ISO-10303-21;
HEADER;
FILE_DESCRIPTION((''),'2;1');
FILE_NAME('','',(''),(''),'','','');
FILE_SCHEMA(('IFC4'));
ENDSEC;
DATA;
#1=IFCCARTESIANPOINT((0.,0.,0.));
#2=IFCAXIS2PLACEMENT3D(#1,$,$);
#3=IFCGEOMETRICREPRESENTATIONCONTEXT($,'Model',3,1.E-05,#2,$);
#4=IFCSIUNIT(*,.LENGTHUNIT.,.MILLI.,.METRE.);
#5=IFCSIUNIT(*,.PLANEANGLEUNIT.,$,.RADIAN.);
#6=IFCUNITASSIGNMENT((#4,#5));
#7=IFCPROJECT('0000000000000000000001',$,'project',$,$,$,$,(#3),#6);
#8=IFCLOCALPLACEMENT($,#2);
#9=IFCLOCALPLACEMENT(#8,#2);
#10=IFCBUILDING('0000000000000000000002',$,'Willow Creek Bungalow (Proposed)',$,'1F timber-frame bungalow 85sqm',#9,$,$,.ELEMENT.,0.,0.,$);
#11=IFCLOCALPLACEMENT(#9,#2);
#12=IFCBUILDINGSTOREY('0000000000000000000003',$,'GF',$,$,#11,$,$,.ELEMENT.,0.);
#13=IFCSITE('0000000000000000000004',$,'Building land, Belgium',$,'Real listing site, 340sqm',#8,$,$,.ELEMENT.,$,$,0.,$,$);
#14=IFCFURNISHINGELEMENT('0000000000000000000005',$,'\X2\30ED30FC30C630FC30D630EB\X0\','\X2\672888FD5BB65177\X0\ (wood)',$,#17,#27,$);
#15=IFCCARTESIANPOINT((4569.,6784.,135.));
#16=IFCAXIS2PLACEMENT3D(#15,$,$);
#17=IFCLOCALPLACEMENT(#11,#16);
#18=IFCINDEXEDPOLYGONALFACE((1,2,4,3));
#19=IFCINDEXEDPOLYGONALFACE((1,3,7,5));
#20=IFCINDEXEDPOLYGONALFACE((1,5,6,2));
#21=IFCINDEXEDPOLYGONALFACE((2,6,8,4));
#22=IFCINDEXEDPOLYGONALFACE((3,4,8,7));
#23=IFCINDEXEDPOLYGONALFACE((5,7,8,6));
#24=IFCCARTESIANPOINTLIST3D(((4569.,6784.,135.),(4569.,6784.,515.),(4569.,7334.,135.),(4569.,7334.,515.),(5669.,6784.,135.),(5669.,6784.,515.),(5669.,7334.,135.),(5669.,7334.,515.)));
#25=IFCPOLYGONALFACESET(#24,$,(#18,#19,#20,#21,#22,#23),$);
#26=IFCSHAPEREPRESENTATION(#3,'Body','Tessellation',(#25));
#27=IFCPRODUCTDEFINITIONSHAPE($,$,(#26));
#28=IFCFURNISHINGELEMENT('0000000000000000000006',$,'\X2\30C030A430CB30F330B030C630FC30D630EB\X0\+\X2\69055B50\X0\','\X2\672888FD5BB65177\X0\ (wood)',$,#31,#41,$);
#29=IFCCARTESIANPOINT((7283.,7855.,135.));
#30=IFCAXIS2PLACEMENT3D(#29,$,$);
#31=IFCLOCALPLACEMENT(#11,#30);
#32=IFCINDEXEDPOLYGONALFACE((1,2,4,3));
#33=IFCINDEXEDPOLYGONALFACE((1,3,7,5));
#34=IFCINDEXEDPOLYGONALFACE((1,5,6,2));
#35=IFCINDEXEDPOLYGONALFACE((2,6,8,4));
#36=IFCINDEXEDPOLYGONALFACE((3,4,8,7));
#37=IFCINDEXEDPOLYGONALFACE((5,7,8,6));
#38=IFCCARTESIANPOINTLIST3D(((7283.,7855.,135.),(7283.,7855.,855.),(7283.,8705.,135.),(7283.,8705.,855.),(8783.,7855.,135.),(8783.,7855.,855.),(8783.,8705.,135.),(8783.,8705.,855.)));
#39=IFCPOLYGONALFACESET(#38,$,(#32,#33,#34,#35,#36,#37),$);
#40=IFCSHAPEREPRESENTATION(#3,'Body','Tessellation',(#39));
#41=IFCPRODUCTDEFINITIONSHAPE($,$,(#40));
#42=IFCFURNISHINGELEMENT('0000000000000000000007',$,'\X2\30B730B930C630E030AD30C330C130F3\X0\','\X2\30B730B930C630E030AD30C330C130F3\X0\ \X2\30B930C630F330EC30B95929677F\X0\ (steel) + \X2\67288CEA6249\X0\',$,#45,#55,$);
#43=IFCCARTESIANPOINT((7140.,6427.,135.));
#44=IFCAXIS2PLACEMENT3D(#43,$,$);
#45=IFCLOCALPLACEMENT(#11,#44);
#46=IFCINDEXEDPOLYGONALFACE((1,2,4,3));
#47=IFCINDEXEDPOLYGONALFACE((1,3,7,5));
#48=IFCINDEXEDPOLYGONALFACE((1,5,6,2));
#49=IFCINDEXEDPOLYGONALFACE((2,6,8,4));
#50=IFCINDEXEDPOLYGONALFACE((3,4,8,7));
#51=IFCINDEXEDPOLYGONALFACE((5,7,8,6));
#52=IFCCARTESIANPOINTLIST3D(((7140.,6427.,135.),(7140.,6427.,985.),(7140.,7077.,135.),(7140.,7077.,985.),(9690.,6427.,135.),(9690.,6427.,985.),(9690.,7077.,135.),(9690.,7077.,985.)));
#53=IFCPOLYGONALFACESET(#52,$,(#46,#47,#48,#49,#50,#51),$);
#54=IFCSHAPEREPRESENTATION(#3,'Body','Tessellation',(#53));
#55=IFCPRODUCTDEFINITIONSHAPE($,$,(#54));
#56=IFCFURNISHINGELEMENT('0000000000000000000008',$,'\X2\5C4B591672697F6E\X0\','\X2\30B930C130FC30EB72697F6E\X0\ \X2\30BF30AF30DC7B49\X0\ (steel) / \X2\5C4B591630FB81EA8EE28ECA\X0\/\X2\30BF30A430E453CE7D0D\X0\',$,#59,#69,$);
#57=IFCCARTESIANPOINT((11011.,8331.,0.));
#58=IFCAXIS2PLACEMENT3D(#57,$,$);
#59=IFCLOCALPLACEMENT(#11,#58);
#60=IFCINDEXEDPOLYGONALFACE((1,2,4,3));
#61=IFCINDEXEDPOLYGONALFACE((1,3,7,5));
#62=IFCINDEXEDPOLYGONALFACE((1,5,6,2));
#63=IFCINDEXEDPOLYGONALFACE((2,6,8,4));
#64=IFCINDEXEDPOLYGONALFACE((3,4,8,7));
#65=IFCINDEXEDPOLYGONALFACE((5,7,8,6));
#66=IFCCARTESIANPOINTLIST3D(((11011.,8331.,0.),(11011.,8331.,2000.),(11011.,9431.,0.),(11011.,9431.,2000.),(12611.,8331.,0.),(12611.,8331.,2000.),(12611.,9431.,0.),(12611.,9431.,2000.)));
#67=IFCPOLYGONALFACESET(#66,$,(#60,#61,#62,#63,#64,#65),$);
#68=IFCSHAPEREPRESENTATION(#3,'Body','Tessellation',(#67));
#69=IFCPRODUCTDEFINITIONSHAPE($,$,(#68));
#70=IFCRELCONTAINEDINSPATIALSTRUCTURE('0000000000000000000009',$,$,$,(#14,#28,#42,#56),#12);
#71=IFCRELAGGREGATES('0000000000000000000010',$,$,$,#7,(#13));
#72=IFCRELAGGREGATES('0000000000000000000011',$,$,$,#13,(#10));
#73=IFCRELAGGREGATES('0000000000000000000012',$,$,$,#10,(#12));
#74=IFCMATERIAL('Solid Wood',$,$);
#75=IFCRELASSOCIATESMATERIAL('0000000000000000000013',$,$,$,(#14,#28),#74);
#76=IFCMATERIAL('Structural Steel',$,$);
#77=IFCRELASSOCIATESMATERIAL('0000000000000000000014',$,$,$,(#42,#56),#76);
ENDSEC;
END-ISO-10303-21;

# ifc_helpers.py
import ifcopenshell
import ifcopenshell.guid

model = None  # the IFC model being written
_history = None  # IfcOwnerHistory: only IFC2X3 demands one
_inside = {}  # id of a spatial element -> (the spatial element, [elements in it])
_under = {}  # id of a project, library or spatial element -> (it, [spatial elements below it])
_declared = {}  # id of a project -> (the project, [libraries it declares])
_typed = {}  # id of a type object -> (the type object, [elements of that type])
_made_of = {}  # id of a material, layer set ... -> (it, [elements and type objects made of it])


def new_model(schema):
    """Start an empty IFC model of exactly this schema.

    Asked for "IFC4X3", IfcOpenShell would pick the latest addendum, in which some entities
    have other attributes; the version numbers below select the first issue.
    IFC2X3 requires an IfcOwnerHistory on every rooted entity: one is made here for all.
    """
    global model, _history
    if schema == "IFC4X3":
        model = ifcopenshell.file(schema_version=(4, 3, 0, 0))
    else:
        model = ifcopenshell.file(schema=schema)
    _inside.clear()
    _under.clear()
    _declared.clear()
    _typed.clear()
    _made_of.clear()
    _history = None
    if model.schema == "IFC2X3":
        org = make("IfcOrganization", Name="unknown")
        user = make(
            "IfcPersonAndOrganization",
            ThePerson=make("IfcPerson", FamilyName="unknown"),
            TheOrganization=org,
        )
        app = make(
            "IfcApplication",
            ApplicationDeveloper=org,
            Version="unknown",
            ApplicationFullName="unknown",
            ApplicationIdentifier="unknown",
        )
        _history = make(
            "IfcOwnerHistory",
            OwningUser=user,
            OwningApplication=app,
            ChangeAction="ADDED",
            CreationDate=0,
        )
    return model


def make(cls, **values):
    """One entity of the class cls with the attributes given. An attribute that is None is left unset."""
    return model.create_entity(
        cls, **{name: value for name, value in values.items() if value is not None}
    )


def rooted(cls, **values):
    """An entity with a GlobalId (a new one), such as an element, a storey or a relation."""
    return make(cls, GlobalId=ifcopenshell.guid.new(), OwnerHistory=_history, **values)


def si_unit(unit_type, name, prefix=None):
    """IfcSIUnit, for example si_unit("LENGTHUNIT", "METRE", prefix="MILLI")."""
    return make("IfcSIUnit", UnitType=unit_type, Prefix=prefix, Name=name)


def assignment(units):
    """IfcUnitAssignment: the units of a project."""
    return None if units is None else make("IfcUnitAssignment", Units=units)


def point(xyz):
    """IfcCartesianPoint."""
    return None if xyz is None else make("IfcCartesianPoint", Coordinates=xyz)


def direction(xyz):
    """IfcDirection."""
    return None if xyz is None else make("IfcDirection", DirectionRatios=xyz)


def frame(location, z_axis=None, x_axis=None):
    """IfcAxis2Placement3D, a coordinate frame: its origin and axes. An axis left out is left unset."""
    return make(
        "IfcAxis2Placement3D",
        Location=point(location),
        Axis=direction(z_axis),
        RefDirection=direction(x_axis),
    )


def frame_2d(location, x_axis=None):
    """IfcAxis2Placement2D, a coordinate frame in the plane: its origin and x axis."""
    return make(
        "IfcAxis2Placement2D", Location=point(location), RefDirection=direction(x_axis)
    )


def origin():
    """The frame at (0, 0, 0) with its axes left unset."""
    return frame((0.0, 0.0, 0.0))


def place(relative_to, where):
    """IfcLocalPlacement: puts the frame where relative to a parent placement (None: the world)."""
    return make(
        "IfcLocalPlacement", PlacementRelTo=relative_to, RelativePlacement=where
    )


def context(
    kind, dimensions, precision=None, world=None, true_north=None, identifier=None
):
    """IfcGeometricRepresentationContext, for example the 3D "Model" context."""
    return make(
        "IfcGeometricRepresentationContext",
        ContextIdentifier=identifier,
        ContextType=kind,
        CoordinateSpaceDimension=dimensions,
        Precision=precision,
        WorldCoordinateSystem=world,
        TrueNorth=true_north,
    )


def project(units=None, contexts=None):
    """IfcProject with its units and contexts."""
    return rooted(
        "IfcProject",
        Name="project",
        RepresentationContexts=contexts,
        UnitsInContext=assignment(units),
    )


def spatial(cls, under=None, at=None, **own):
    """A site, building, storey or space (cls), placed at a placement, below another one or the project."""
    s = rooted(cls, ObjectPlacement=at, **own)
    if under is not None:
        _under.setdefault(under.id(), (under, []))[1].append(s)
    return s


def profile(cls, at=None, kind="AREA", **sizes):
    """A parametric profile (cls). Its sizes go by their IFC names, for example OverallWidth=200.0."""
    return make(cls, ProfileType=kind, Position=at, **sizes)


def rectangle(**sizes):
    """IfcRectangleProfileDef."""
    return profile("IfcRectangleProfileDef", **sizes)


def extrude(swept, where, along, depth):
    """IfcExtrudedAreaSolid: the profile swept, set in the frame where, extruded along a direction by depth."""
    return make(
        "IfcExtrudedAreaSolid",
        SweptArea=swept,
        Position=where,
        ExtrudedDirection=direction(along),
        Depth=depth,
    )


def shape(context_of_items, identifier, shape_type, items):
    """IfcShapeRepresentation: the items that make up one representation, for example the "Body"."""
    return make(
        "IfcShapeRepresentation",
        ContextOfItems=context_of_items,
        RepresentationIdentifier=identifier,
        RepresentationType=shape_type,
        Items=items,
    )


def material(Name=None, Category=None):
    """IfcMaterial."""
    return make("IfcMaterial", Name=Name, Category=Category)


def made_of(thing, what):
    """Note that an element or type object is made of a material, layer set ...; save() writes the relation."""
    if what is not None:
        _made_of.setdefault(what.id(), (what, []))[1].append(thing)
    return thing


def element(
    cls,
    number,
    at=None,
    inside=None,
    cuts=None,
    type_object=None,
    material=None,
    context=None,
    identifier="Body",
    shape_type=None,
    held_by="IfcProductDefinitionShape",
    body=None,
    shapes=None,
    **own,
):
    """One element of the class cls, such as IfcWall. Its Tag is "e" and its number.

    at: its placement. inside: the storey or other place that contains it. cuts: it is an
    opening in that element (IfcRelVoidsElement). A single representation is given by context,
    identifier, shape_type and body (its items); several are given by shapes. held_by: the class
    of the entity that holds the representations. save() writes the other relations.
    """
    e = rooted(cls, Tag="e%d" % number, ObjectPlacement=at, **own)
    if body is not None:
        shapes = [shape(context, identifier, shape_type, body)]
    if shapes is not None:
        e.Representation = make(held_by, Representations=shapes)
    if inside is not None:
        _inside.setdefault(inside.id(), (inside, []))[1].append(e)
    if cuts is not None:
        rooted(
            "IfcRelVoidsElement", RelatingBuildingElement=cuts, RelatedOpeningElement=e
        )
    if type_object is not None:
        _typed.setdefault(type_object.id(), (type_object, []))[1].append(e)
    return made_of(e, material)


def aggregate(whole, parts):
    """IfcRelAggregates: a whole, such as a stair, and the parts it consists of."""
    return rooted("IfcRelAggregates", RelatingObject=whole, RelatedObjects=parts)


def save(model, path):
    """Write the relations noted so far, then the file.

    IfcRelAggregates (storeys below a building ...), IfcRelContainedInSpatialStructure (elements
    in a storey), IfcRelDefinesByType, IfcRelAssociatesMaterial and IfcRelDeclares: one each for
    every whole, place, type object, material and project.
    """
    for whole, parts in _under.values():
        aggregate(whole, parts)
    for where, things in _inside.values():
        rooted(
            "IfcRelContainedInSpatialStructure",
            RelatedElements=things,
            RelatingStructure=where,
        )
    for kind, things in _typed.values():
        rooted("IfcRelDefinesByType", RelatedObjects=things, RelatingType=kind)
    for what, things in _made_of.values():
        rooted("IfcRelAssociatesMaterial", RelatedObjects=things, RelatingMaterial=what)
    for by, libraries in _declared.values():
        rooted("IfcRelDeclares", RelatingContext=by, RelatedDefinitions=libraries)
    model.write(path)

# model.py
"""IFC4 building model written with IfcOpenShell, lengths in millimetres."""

from ifc_helpers import new_model, si_unit, frame, frame_2d, origin, place, context, project, spatial, rectangle, extrude, material, element, save


model = new_model("IFC4")

# Units and contexts
model_context = context("Model", 3, precision=1e-05, world=origin())
ifc_project = project(units=[si_unit("LENGTHUNIT", "METRE", prefix="MILLI"), si_unit("PLANEANGLEUNIT", "RADIAN")], contexts=[model_context])

# Site, building, storey
site_placement = place(None, origin())
site = spatial("IfcSite", under=ifc_project, at=site_placement, Name="Building land, Belgium", ObjectType="Real listing site, 340sqm", CompositionType="ELEMENT", RefElevation=0.0)
building_placement = place(site_placement, origin())
building = spatial("IfcBuilding", under=site, at=building_placement, Name="Willow Creek Bungalow (Proposed)", ObjectType="1F timber-frame bungalow 85sqm", CompositionType="ELEMENT", ElevationOfRefHeight=0.0, ElevationOfTerrain=0.0)
storey_placement = place(building_placement, origin())
storey = spatial("IfcBuildingStorey", under=building, at=storey_placement, Name="GF", CompositionType="ELEMENT", Elevation=0.0)

# Shared definitions
ifc_material_1 = material(Name="Solid Wood")

# Shared definitions
ifc_material_2 = material(Name="Structural Steel")

# Furnishing elements
furnishing_1_placement = place(storey_placement, frame((4569.0, 6784.0, 135.0)))
element("IfcFurnishingElement", 1, at=furnishing_1_placement, inside=storey, material=ifc_material_1, Name="ローテーブル", Description="木製家具 (wood)", context=model_context, shape_type="SweptSolid", body=[
    extrude(rectangle(XDim=1100.0, YDim=550.0, at=frame_2d((550.0, 275.0))), frame((4569.0, 6784.0, 135.0)), (0.0, 0.0, 1.0), 380.0),
])
furnishing_2_placement = place(storey_placement, frame((7283.0, 7855.0, 135.0)))
element("IfcFurnishingElement", 2, at=furnishing_2_placement, inside=storey, material=ifc_material_1, Name="ダイニングテーブル+椅子", Description="木製家具 (wood)", context=model_context, shape_type="SweptSolid", body=[
    extrude(rectangle(XDim=1500.0, YDim=850.0, at=frame_2d((750.0, 425.0))), frame((7283.0, 7855.0, 135.0)), (0.0, 0.0, 1.0), 720.0),
])
furnishing_3_placement = place(storey_placement, frame((7140.0, 6427.0, 135.0)))
element("IfcFurnishingElement", 3, at=furnishing_3_placement, inside=storey, material=ifc_material_2, Name="システムキッチン", Description="システムキッチン ステンレス天板 (steel) + 木質扉", context=model_context, shape_type="SweptSolid", body=[
    extrude(rectangle(XDim=2550.0, YDim=650.0, at=frame_2d((1275.0, 325.0))), frame((7140.0, 6427.0, 135.0)), (0.0, 0.0, 1.0), 850.0),
])
furnishing_4_placement = place(storey_placement, frame((11011.0, 8331.0, 0.0)))
element("IfcFurnishingElement", 4, at=furnishing_4_placement, inside=storey, material=ifc_material_2, Name="屋外物置", Description="スチール物置 タクボ等 (steel) / 屋外・自転車/タイヤ収納", context=model_context, shape_type="SweptSolid", body=[
    extrude(rectangle(XDim=1600.0, YDim=1100.0, at=frame_2d((800.0, 550.0))), frame((11011.0, 8331.0, 0.0)), (0.0, 0.0, 1.0), 2000.0),
])

save(model, "model.ifc")
